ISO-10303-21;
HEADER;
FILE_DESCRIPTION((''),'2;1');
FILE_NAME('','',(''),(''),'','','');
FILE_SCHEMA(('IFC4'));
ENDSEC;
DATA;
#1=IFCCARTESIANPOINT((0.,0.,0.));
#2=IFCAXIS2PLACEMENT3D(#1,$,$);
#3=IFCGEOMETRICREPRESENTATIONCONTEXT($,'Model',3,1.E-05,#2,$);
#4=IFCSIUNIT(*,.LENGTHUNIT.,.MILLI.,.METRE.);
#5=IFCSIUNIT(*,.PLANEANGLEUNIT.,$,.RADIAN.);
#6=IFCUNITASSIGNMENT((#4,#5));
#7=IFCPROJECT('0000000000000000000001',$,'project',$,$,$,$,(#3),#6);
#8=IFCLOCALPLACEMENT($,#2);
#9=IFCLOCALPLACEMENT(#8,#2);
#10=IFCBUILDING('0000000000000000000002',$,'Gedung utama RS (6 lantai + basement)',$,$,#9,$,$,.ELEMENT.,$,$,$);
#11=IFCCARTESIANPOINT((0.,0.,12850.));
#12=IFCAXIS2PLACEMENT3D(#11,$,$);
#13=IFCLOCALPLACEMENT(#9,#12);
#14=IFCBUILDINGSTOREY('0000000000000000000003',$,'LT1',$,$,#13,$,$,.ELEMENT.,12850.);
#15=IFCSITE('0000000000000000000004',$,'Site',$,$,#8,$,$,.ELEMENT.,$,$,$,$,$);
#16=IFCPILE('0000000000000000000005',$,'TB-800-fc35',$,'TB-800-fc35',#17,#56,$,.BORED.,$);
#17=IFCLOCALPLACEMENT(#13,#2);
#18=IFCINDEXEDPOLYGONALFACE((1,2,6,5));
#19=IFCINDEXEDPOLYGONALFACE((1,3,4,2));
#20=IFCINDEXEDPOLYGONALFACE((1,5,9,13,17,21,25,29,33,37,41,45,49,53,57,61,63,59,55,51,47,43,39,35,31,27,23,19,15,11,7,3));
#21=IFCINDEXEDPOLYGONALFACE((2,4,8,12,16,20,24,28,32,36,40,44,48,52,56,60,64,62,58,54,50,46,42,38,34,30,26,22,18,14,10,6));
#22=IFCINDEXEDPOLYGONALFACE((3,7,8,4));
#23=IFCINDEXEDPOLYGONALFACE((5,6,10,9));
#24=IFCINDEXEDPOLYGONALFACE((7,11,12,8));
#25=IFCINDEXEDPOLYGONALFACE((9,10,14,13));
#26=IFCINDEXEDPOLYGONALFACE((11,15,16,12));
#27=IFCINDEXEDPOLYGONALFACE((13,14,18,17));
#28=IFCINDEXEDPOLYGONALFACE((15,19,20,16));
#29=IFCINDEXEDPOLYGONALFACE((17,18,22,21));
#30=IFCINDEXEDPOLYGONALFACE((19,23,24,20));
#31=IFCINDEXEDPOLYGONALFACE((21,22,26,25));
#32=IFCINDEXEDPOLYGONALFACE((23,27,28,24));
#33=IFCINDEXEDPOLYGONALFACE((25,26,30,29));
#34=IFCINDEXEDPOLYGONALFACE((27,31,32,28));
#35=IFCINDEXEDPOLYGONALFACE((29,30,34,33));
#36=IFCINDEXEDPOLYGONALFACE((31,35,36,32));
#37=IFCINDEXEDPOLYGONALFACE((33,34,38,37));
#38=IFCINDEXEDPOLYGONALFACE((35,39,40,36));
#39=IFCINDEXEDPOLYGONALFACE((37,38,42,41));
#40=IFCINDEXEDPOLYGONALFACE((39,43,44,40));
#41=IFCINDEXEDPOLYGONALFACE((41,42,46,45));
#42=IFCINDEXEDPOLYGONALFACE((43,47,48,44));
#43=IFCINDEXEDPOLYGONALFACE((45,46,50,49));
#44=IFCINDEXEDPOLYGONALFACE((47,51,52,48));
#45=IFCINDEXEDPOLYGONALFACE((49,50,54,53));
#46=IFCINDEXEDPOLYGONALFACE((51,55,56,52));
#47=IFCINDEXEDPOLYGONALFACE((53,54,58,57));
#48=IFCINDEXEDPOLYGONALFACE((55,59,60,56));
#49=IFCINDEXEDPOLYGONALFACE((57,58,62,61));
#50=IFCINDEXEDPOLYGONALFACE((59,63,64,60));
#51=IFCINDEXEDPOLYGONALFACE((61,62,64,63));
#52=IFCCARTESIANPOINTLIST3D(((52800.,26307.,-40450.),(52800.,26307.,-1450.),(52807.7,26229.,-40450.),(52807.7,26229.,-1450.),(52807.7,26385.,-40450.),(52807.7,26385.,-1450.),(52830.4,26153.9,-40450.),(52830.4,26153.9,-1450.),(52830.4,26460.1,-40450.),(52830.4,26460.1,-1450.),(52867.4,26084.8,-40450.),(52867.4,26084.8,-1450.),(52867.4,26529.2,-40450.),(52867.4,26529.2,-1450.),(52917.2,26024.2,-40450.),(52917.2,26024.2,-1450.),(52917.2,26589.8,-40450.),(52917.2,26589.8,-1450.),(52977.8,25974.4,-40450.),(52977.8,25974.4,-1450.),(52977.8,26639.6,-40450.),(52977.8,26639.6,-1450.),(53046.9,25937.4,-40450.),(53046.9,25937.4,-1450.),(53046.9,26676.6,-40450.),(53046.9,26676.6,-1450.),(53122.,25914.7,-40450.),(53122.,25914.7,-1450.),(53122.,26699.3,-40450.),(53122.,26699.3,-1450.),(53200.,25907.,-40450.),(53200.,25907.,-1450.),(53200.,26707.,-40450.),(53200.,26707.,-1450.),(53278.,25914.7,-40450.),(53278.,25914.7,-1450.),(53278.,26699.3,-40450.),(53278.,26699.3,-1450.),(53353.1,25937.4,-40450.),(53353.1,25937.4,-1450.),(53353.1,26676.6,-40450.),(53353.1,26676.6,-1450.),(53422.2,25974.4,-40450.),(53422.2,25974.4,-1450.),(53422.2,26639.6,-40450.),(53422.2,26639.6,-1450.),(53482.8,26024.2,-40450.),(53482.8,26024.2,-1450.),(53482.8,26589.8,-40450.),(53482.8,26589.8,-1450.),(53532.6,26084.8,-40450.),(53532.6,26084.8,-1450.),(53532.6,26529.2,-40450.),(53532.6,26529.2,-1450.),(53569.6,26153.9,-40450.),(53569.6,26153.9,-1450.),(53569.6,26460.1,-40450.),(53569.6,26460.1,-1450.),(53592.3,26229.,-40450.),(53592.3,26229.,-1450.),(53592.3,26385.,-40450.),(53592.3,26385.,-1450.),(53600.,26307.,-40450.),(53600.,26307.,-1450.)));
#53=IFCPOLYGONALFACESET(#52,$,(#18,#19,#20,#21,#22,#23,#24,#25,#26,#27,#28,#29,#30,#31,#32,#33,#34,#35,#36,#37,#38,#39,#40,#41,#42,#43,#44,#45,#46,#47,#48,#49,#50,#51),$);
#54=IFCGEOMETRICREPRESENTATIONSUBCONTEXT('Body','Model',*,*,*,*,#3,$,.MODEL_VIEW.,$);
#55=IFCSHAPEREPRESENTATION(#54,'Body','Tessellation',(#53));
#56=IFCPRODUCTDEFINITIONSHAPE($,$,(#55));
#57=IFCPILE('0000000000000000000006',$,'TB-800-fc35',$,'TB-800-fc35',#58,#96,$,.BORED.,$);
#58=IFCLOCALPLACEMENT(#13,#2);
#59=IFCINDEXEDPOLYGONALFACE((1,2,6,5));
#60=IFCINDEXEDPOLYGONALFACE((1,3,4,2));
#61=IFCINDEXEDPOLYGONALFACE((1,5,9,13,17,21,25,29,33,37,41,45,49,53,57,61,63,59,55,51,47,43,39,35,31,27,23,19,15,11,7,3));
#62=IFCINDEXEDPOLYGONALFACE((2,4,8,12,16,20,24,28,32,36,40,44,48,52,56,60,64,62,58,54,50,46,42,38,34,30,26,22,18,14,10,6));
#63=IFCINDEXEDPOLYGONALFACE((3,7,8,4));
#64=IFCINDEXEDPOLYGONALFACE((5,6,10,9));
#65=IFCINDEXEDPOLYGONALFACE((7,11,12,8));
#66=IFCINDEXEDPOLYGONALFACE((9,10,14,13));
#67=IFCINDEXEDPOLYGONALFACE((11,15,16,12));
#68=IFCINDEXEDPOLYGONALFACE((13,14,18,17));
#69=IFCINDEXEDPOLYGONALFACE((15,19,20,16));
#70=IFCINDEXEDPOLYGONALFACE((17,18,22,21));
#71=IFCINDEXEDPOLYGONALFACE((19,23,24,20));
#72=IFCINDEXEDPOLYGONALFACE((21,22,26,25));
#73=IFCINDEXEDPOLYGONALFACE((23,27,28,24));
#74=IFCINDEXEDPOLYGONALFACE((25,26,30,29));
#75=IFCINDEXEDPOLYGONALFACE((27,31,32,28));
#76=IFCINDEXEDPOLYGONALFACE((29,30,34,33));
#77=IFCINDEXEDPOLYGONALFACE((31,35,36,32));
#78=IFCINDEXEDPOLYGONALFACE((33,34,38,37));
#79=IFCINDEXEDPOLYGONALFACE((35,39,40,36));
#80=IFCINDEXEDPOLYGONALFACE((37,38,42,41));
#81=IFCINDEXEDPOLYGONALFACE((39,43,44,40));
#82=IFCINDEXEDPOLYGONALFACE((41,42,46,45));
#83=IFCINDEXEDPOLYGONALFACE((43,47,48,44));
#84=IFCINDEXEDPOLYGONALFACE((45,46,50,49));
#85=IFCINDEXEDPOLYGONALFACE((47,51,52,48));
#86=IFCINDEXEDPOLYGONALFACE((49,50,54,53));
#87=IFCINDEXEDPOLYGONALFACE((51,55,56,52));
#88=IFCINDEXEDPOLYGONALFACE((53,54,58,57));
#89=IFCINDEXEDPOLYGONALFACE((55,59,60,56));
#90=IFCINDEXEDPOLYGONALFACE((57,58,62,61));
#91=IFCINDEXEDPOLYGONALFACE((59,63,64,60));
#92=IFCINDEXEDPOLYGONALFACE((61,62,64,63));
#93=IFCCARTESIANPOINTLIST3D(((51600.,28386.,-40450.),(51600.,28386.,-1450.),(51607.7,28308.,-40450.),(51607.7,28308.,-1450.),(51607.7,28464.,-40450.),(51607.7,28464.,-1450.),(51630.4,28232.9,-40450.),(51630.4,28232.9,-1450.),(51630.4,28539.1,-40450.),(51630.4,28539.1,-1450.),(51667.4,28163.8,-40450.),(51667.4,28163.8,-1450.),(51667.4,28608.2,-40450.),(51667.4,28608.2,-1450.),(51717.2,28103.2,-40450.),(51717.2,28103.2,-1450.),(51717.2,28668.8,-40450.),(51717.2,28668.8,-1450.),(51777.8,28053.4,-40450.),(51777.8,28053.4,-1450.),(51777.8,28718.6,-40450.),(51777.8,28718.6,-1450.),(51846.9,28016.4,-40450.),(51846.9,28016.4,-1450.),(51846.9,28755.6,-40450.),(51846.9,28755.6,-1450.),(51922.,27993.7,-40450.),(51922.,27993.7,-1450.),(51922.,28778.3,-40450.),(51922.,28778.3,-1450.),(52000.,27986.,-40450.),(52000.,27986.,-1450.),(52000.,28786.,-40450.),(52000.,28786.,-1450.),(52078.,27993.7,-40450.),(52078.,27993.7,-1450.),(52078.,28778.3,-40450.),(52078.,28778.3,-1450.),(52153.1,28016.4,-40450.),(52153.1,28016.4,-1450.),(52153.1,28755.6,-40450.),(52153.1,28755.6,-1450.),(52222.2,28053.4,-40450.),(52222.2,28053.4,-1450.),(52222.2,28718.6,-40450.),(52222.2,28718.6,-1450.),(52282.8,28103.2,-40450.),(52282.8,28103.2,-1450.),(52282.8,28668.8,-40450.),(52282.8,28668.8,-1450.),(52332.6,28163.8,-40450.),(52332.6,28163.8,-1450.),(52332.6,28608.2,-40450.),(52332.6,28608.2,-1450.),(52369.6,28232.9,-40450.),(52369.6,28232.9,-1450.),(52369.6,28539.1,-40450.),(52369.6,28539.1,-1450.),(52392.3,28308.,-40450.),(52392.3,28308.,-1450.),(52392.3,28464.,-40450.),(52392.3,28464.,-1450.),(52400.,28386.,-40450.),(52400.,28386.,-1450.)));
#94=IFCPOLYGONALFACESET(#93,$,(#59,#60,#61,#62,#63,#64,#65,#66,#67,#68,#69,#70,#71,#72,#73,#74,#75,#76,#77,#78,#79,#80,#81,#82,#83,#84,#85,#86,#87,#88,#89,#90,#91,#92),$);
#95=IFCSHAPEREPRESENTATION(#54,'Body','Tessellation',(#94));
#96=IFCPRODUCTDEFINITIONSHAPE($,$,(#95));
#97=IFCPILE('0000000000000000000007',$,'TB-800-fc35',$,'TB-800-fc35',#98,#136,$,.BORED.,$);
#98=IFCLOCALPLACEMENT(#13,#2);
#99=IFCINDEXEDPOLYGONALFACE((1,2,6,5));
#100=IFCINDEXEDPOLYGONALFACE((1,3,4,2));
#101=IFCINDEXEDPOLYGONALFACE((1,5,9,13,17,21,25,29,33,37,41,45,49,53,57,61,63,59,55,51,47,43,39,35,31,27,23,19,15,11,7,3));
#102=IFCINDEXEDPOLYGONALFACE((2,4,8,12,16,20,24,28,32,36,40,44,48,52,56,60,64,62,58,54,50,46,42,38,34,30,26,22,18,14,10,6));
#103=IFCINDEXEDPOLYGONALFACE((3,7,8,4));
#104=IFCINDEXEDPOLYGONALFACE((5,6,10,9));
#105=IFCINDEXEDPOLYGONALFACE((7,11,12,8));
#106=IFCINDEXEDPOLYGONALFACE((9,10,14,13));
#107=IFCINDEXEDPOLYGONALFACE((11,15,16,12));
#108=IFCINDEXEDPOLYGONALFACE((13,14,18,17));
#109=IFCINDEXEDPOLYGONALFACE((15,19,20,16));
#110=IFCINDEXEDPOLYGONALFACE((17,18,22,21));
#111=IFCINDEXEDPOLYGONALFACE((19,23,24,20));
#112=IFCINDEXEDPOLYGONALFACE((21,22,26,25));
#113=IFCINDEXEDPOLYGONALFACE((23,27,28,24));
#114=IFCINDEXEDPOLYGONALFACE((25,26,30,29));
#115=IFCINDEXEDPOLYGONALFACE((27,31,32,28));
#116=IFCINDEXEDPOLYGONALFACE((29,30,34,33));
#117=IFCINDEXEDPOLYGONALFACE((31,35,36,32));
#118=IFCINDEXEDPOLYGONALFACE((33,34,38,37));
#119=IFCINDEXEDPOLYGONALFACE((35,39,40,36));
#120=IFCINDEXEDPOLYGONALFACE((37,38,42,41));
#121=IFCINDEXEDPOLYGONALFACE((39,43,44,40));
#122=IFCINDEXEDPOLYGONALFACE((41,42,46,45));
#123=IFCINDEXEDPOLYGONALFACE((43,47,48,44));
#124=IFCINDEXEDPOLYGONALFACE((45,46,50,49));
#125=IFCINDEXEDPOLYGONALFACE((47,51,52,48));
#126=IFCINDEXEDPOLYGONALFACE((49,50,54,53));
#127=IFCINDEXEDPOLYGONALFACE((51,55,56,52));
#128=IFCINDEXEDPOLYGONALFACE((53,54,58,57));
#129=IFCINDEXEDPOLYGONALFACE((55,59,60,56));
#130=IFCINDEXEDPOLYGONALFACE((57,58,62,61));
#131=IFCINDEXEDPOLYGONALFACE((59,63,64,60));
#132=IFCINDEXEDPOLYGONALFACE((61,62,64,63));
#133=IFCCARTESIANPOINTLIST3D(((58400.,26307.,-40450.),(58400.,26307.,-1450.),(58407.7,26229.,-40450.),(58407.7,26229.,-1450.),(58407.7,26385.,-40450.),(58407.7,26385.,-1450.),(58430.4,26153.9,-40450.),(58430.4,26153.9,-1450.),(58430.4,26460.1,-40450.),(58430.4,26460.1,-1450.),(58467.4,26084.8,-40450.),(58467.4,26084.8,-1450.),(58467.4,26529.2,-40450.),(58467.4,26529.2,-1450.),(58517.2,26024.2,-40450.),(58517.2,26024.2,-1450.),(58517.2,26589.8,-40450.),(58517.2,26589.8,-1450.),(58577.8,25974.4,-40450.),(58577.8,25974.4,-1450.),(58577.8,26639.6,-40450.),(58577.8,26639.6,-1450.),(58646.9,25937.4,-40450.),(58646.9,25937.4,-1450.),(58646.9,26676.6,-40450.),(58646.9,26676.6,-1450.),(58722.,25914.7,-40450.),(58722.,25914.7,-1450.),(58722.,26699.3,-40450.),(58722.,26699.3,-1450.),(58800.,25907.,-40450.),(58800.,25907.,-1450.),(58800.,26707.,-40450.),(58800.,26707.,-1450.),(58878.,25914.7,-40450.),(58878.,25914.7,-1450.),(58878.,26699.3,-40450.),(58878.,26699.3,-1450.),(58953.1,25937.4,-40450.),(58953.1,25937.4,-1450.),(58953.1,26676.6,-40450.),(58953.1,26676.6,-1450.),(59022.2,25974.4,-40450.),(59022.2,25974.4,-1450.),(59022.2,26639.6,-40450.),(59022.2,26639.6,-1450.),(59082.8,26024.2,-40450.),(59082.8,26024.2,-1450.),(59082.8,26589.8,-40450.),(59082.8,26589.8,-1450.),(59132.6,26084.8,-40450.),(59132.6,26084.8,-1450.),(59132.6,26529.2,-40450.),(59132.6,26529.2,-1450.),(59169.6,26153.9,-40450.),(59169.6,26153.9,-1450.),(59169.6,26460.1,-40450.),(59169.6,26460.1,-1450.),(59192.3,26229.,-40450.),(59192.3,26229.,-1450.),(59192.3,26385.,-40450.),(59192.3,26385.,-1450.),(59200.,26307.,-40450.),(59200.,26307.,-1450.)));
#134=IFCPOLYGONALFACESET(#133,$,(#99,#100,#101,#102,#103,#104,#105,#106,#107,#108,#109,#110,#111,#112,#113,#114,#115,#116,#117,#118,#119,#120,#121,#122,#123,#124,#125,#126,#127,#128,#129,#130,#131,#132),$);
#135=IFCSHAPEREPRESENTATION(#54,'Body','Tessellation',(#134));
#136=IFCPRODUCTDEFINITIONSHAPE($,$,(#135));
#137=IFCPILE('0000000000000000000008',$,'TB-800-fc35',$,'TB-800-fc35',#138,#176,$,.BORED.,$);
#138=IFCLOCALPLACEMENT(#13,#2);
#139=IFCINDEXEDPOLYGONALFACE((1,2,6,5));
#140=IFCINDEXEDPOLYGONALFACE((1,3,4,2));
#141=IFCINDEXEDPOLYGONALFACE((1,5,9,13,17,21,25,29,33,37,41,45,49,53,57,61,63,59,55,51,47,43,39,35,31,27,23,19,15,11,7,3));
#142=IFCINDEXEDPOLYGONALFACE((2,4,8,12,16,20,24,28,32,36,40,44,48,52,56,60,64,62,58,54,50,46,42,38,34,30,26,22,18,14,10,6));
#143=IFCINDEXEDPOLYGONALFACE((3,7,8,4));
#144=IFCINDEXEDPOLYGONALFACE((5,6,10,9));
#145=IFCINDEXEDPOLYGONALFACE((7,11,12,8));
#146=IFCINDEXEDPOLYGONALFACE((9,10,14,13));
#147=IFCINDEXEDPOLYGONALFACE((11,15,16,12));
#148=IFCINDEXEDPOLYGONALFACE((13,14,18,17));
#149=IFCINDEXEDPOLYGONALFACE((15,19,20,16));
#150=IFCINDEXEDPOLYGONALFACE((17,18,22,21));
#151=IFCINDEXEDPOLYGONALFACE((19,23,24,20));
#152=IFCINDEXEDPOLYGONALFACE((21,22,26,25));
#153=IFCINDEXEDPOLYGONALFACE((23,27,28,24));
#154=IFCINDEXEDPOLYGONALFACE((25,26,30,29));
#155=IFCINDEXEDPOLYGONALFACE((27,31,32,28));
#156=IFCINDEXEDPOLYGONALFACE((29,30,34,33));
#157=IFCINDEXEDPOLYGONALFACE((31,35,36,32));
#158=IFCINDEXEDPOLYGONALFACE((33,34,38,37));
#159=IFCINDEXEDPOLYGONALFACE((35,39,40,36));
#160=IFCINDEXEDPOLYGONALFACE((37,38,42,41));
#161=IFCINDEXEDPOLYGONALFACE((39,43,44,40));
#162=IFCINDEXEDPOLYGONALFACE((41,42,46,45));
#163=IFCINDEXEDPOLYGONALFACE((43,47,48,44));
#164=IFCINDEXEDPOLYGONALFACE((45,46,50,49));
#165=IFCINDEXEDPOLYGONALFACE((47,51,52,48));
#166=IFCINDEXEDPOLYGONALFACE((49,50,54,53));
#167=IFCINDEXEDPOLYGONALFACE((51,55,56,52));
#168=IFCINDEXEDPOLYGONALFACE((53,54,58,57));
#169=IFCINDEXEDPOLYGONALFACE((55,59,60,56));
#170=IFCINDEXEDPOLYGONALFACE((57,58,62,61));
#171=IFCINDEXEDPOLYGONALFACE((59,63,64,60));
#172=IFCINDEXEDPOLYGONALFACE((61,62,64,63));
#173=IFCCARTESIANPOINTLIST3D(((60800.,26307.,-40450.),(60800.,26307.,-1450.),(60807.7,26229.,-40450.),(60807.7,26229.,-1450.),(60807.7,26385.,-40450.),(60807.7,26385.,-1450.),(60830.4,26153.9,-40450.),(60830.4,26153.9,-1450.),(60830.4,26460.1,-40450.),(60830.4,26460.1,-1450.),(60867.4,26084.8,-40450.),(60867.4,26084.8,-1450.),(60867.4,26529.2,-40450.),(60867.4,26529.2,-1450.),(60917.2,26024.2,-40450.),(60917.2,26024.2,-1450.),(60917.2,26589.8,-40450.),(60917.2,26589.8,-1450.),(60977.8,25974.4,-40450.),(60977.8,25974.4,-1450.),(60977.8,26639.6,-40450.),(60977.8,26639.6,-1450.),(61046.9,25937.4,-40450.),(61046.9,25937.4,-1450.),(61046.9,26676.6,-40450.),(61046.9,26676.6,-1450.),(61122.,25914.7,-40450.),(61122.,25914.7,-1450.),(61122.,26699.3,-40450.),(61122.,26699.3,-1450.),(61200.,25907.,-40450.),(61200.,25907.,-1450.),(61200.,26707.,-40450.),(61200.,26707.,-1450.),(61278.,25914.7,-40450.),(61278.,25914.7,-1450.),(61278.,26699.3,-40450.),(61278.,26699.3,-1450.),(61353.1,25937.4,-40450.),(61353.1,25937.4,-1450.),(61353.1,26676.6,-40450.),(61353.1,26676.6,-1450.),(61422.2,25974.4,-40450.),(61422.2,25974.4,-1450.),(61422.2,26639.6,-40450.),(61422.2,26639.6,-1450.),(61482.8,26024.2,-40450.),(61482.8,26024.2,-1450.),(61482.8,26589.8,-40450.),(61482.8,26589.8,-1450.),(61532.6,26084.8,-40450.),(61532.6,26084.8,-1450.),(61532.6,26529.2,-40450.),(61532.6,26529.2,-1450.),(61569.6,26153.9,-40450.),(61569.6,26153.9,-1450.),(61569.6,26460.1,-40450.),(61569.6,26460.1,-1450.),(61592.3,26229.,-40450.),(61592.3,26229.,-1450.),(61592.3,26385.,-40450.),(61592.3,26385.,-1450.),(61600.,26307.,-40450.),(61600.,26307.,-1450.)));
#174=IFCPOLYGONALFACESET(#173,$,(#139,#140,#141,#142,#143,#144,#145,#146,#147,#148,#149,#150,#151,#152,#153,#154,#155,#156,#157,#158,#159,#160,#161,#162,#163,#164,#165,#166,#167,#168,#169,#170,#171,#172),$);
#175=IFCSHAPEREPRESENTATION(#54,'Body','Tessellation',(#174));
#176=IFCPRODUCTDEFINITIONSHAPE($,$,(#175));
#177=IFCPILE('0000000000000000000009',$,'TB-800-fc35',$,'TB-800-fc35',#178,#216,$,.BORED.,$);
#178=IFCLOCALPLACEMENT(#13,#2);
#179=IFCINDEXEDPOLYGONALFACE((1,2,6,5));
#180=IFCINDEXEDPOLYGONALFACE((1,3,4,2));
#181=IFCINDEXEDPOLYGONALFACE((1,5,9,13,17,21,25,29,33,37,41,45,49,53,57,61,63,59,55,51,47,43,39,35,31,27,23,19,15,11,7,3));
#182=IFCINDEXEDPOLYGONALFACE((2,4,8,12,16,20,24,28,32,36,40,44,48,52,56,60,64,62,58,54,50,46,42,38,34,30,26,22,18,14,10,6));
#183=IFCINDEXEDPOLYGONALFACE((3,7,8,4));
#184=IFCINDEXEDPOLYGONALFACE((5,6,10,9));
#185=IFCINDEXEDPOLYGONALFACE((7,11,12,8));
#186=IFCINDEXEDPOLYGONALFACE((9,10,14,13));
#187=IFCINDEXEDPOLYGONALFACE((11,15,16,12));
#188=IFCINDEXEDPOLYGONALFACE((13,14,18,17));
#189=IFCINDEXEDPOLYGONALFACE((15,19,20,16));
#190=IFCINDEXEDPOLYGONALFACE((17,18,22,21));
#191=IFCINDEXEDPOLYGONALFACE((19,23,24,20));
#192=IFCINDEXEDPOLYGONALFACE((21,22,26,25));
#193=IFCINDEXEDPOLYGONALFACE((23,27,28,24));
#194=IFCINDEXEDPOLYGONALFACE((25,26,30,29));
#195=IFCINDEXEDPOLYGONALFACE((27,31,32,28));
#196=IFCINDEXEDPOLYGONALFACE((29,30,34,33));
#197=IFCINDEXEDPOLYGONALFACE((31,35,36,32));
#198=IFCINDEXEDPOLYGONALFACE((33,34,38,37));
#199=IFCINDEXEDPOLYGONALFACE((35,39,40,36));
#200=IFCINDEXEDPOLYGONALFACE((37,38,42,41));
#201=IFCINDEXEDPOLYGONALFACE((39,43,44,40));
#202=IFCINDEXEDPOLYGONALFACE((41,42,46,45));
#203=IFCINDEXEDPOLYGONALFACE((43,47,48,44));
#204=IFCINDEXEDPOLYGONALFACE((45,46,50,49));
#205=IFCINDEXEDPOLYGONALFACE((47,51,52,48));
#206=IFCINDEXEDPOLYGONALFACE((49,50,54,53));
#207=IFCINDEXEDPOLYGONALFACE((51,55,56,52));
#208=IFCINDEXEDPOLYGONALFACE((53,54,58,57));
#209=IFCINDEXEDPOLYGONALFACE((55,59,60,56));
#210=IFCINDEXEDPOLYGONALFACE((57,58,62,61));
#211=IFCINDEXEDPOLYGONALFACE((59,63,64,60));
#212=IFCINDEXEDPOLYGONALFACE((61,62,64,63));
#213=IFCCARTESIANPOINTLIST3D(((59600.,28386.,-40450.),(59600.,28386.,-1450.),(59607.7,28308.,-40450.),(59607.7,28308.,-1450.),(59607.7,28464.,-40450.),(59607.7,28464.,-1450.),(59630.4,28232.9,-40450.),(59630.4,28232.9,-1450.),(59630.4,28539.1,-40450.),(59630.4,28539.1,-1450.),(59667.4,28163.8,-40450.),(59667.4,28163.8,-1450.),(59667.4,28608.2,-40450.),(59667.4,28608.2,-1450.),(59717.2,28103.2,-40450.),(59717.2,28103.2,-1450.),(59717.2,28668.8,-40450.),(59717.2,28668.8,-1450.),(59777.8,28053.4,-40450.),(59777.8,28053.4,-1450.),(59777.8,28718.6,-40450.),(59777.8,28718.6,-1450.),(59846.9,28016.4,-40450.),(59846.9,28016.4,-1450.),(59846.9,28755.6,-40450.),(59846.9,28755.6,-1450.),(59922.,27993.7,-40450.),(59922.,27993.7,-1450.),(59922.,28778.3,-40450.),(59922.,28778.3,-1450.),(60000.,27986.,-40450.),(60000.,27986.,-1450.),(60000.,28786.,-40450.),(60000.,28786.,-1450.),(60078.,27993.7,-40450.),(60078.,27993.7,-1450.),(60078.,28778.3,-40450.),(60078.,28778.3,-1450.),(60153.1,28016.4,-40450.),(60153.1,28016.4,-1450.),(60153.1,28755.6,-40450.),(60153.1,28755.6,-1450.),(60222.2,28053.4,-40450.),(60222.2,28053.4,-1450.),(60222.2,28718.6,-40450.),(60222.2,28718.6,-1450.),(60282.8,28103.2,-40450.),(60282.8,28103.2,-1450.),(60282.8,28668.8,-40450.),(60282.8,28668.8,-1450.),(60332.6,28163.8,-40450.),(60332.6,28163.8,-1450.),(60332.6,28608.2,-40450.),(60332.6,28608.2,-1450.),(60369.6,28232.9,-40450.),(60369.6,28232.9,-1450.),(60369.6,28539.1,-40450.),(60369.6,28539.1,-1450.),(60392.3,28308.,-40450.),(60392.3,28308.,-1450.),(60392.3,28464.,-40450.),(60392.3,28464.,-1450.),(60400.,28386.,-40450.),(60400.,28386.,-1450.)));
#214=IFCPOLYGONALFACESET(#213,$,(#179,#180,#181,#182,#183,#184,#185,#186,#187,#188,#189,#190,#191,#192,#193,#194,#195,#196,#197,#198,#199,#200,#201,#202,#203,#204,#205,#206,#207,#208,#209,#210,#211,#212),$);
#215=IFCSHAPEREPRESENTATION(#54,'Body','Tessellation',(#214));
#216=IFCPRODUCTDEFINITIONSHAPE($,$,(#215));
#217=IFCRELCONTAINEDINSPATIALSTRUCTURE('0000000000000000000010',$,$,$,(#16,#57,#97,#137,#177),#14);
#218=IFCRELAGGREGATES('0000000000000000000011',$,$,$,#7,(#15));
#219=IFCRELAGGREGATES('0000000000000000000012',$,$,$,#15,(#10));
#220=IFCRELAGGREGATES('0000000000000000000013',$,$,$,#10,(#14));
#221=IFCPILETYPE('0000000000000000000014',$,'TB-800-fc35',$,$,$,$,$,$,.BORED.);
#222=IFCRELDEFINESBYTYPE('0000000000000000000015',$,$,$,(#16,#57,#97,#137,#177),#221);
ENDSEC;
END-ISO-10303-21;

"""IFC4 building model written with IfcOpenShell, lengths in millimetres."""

from ifc_helpers import new_model, si_unit, frame, origin, origin_2d, place, context, subcontext, project, spatial, circle, extrude, material_profile, profile_set, profile_usage, type_object, element, save


model = new_model("IFC4")

# Units and contexts
model_context = context("Model", 3, precision=1e-05, world=origin())
body_context = subcontext(model_context, "Body", "Model", "MODEL_VIEW")
ifc_project = project(units=[si_unit("LENGTHUNIT", "METRE", prefix="MILLI"), si_unit("PLANEANGLEUNIT", "RADIAN")], contexts=[model_context])

# Site, building, storey
site_placement = place(None, origin())
site = spatial("IfcSite", under=ifc_project, at=site_placement, Name="Site", CompositionType="ELEMENT")
building_placement = place(site_placement, origin())
building = spatial("IfcBuilding", under=site, at=building_placement, Name="Gedung utama RS (6 lantai + basement)", CompositionType="ELEMENT")
storey_placement = place(building_placement, frame((0.0, 0.0, 12850.0)))
storey = spatial("IfcBuildingStorey", under=building, at=storey_placement, Name="LT1", CompositionType="ELEMENT", Elevation=12850.0)

# Piles
ifc_material_profile = material_profile(None, circle(Radius=400.0, at=origin_2d()), Name="TB-800-fc35")
ifc_profile_set = profile_set([ifc_material_profile], Name="TB-800-fc35")
ifc_profile_usage = profile_usage(ifc_profile_set, cardinal=5)
pile_type = type_object("IfcPileType", Name="TB-800-fc35", PredefinedType="BORED", material=ifc_profile_set)
for number, where, z_axis, x_axis, name in (
    (1, (53200.0, 26307.0, -40450.0), (0.0, 0.0, 1.0), (1.0, 0.0, 0.0), "TB-800-fc35"),
    (2, (52000.0, 28386.0, -40450.0), (0.0, 0.0, 1.0), (1.0, 0.0, 0.0), "TB-800-fc35"),
    (3, (58800.0, 26307.0, -40450.0), (0.0, 0.0, 1.0), (1.0, 0.0, 0.0), "TB-800-fc35"),
    (4, (61200.0, 26307.0, -40450.0), (0.0, 0.0, 1.0), (1.0, 0.0, 0.0), "TB-800-fc35"),
    (5, (60000.0, 28386.0, -40450.0), (0.0, 0.0, 1.0), (1.0, 0.0, 0.0), "TB-800-fc35"),
):
    element("IfcPile", number, at=place(storey_placement, frame(where, z_axis=z_axis, x_axis=x_axis)), inside=storey, type_object=pile_type, material=ifc_profile_usage, Name=name, ObjectType="TB-800-fc35", PredefinedType="BORED", context=body_context, shape_type="SweptSolid", body=[
        extrude(circle(Radius=400.0, at=origin_2d()), origin(), (0.0, 0.0, 1.0), 39000.0),
    ])

save(model, "model.ifc")
